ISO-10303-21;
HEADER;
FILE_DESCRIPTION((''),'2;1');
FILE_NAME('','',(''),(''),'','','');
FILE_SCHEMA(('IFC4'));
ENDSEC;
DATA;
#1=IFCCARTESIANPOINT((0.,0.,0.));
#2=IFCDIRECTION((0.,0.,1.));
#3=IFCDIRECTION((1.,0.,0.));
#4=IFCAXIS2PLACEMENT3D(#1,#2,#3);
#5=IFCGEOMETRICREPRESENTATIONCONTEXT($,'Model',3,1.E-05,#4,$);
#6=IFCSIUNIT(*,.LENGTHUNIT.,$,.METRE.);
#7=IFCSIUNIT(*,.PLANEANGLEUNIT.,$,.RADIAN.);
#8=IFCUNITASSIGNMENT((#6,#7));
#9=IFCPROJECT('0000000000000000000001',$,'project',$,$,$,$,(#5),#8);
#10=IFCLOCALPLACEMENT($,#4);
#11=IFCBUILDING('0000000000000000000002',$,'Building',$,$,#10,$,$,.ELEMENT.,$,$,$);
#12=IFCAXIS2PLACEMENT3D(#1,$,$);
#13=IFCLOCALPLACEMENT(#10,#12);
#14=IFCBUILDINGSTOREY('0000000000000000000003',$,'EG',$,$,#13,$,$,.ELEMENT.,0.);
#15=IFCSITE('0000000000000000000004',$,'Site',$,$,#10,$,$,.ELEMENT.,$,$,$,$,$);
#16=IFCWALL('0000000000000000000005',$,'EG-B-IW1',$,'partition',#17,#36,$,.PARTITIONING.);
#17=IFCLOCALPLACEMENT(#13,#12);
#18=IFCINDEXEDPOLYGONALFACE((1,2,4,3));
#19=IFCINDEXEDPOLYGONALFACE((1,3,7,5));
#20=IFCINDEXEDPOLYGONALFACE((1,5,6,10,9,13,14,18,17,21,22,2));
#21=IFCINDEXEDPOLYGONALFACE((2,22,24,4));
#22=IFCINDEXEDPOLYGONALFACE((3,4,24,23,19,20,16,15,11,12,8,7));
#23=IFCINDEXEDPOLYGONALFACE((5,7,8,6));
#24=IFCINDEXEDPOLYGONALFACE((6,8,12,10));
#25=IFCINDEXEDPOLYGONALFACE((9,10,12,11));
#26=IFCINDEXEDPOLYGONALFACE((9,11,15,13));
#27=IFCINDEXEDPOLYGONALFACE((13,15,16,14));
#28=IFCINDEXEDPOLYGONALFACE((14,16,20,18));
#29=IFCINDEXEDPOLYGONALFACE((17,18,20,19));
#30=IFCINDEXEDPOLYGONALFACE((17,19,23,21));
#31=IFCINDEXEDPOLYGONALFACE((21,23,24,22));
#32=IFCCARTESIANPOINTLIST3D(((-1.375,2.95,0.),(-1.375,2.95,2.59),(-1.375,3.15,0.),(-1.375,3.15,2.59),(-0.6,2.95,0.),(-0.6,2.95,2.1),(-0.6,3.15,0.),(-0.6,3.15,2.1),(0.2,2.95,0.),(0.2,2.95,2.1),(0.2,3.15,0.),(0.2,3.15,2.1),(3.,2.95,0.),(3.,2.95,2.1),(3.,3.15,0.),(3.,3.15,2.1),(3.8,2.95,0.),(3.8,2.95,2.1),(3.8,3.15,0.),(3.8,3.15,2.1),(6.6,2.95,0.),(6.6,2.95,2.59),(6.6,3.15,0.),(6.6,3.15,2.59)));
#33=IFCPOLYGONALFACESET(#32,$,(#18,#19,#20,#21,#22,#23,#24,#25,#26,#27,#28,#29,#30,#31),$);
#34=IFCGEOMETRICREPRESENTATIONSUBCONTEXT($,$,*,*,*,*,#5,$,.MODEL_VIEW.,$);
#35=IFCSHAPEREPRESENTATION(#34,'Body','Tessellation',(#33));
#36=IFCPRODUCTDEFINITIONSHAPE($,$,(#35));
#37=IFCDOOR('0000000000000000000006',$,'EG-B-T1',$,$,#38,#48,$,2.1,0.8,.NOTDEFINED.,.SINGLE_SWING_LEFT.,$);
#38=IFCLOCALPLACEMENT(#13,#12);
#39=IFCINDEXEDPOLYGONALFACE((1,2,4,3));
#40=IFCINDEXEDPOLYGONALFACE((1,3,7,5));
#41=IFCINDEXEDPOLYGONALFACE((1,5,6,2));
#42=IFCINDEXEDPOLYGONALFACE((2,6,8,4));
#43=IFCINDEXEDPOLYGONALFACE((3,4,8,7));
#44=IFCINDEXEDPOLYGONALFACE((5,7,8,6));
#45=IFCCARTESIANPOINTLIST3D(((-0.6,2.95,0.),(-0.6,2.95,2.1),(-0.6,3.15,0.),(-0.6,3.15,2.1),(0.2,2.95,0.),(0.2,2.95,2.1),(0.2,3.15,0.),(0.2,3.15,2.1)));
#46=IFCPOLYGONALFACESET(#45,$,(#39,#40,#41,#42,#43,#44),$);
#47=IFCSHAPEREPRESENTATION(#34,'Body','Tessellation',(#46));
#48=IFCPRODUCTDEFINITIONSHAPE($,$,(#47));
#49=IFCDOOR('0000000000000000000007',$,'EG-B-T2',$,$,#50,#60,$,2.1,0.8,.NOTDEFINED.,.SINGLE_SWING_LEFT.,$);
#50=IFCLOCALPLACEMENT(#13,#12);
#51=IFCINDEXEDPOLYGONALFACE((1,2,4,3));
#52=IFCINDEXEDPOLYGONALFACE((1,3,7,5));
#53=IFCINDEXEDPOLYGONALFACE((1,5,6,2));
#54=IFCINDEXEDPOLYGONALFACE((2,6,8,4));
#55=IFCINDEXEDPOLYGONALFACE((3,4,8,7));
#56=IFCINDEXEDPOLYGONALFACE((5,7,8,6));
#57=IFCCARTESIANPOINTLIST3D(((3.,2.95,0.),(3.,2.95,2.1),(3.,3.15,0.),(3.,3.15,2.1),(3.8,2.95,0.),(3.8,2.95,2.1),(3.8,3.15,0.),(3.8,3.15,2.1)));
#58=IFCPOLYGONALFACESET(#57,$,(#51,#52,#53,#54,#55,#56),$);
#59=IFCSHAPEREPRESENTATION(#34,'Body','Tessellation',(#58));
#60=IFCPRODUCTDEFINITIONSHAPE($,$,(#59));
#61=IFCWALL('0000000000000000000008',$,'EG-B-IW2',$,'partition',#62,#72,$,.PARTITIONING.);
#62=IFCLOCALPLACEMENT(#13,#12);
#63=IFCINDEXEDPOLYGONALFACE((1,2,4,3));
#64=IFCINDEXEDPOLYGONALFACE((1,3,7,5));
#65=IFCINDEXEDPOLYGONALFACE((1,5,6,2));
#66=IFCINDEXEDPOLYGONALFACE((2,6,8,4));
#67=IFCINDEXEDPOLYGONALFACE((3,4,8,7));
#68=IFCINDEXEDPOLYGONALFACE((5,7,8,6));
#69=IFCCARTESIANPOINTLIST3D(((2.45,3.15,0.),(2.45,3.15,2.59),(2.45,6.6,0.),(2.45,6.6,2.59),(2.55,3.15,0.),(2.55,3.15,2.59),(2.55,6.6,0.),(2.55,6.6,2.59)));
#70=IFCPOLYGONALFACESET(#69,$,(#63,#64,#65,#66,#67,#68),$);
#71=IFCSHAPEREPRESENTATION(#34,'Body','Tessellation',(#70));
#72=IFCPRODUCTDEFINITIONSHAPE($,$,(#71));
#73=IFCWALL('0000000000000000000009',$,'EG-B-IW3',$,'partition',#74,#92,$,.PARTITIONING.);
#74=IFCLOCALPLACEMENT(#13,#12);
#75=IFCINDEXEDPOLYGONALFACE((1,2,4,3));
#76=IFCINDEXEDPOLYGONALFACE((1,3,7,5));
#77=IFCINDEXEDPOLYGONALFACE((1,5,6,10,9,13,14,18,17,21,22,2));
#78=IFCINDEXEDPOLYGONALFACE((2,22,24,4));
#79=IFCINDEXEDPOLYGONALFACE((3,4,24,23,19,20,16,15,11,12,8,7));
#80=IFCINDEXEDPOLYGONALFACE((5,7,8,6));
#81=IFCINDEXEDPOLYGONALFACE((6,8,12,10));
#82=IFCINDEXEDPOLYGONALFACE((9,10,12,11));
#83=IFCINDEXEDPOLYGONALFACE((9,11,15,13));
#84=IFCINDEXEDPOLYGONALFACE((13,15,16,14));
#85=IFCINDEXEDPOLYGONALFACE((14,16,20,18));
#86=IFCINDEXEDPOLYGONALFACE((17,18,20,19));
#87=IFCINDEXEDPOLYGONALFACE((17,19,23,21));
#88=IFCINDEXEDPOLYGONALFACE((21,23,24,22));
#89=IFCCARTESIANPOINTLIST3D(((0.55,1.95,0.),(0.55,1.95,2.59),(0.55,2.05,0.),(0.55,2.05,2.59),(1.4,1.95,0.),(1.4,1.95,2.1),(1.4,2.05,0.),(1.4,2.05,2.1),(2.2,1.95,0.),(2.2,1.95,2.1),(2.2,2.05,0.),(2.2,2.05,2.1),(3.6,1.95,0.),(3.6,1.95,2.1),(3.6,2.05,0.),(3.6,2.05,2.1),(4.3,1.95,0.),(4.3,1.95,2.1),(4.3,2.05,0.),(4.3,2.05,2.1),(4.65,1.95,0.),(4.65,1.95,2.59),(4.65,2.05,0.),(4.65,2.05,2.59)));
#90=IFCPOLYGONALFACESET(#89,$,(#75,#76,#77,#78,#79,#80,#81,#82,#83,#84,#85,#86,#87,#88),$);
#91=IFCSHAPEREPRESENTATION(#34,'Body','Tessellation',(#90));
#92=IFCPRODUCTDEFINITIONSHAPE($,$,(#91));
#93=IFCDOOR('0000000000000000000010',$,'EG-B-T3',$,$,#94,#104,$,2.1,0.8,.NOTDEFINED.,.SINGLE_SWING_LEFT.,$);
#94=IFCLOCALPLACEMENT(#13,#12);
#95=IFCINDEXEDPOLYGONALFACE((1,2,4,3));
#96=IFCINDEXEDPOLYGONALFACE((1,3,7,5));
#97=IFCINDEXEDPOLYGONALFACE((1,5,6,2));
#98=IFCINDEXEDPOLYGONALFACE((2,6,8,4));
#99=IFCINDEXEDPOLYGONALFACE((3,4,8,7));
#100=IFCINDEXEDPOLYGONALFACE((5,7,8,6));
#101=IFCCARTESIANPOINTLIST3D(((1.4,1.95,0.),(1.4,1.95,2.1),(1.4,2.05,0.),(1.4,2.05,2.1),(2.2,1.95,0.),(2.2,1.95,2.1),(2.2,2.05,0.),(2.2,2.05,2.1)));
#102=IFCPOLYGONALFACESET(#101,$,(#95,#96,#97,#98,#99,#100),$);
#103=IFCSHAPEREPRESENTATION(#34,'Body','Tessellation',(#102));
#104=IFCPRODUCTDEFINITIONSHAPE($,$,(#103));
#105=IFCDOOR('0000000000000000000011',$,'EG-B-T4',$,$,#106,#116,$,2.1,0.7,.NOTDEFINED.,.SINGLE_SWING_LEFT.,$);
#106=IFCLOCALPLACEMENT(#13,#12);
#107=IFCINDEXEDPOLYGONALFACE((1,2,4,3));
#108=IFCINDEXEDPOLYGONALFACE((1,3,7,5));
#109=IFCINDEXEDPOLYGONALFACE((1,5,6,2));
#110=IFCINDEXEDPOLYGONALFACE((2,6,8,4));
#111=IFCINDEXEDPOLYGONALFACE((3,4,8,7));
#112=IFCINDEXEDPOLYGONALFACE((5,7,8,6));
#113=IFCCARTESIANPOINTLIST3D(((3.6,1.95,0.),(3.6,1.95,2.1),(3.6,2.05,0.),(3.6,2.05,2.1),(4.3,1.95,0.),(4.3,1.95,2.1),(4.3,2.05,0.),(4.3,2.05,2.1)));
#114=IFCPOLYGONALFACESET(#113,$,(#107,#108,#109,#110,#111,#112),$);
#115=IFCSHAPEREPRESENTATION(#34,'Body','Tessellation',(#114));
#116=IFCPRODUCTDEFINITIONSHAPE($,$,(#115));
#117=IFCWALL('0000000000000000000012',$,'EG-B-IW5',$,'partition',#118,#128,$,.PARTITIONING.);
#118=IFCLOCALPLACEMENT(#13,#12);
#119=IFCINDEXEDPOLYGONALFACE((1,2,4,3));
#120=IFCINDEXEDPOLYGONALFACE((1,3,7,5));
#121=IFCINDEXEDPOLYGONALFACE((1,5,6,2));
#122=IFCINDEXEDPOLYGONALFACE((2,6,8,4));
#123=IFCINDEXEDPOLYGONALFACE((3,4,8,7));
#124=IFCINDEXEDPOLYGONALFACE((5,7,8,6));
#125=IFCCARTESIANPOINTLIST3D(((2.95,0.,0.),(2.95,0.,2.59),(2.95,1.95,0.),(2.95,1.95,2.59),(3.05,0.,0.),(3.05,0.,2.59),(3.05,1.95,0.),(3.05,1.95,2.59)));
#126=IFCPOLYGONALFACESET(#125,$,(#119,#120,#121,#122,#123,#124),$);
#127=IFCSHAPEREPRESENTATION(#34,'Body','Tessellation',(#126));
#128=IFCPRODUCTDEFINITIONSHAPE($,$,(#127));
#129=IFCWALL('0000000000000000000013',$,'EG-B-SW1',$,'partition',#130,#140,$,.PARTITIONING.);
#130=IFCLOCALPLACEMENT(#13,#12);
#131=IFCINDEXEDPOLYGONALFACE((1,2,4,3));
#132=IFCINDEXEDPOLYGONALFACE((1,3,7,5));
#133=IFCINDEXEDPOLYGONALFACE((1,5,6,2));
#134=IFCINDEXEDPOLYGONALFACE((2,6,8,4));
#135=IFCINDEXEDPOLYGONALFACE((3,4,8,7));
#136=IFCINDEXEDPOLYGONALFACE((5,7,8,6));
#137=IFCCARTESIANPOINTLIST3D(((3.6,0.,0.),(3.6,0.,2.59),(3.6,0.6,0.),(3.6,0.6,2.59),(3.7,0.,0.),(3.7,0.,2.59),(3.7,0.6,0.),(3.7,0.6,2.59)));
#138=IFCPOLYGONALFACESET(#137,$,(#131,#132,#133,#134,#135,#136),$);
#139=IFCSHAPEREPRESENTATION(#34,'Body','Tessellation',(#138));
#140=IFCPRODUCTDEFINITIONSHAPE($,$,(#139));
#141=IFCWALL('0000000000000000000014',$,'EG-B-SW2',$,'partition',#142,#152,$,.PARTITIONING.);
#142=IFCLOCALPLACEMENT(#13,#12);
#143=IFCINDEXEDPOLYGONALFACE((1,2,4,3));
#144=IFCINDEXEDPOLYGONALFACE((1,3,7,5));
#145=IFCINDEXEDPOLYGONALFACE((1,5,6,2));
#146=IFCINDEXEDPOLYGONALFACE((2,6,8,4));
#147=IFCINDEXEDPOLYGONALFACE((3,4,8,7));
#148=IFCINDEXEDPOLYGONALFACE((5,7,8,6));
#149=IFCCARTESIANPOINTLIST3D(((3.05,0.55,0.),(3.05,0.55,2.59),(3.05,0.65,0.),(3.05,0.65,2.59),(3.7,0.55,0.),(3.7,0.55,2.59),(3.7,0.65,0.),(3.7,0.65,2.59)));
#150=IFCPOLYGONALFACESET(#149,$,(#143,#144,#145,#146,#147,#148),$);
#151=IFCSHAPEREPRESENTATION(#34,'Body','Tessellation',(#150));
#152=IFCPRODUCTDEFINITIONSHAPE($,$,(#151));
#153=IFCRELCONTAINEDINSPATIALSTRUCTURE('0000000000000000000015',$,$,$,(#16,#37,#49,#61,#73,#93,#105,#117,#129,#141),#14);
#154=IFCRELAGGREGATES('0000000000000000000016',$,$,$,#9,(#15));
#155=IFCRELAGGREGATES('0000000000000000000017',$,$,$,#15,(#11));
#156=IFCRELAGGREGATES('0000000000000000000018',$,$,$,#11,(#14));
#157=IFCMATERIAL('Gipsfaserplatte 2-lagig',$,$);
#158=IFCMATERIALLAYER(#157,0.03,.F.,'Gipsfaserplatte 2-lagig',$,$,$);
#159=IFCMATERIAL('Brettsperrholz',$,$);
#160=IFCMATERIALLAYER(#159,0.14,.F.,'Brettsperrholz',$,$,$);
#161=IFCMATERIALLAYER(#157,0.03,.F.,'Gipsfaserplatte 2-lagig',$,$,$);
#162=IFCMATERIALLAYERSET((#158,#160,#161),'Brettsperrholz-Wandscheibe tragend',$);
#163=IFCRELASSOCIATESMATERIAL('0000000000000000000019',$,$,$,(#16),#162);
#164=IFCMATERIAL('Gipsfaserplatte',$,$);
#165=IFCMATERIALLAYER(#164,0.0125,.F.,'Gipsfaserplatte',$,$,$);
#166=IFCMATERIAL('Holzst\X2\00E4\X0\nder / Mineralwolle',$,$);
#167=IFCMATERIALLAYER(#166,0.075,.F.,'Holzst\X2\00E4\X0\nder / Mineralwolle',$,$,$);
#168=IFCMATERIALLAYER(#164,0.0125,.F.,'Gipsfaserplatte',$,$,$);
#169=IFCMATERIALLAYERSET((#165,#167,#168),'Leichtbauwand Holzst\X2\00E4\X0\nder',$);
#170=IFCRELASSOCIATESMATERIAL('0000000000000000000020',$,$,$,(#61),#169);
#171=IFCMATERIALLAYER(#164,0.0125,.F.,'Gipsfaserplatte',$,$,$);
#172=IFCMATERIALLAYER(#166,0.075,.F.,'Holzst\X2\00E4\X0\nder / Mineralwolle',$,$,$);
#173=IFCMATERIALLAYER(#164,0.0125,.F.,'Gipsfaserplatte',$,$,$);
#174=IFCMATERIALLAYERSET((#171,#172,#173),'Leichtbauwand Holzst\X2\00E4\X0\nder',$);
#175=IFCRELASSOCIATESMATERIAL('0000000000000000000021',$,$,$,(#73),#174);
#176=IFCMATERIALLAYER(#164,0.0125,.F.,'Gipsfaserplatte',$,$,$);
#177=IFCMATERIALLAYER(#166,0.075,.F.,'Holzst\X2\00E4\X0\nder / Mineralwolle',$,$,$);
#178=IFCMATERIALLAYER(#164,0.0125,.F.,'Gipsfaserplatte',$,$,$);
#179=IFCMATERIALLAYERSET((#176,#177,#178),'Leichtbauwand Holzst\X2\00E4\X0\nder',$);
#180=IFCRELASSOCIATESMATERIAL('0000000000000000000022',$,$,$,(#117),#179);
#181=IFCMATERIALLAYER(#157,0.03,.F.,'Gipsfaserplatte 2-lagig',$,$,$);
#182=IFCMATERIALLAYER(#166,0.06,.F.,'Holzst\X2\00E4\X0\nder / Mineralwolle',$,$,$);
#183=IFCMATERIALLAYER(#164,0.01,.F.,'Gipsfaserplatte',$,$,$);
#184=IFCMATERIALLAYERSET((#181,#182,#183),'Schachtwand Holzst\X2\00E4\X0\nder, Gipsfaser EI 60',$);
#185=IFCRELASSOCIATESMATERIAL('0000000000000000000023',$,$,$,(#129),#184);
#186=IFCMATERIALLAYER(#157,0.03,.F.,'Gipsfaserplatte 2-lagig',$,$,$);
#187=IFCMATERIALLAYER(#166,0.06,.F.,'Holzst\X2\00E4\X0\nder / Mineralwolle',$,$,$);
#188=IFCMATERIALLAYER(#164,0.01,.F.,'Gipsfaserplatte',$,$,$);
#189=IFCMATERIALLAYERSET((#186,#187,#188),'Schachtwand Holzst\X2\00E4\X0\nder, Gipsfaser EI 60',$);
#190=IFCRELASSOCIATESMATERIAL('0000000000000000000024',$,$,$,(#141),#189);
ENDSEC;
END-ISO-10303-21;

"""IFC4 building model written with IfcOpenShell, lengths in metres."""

from ifc_helpers import new_model, si_unit, frame, frame_2d, origin, origin_with_axes, place, context, subcontext, project, spatial, rectangle, extrude, material, layer, layer_set, element, fill, save


model = new_model("IFC4")

# Units and contexts
model_context = context("Model", 3, precision=1e-05, world=origin_with_axes())
sub_context = subcontext(model_context, None, None, "MODEL_VIEW")
ifc_project = project(units=[si_unit("LENGTHUNIT", "METRE"), si_unit("PLANEANGLEUNIT", "RADIAN")], contexts=[model_context])

# Site, building, storey
placement = place(None, origin_with_axes())
site = spatial("IfcSite", under=ifc_project, at=placement, Name="Site", CompositionType="ELEMENT")
building = spatial("IfcBuilding", under=site, at=placement, Name="Building", CompositionType="ELEMENT")
storey_placement = place(placement, origin())
storey = spatial("IfcBuildingStorey", under=building, at=storey_placement, Name="EG", CompositionType="ELEMENT", Elevation=0.0)

# Shared definitions
ifc_material_1 = material(Name="Gipsfaserplatte")

# Wall, openings, doors
ifc_material_2 = material(Name="Gipsfaserplatte 2-lagig")
ifc_layer_1 = layer(ifc_material_2, 0.03, ventilated=False, Name="Gipsfaserplatte 2-lagig")
ifc_material_3 = material(Name="Brettsperrholz")
ifc_layer_2 = layer(ifc_material_3, 0.14, ventilated=False, Name="Brettsperrholz")
ifc_layer_3 = layer(ifc_material_2, 0.03, ventilated=False, Name="Gipsfaserplatte 2-lagig")
ifc_layer_set_1 = layer_set([ifc_layer_1, ifc_layer_2, ifc_layer_3], Name="Brettsperrholz-Wandscheibe tragend")
wall_1_placement = place(storey_placement, frame((-1.375, 3.05, 0.0), z_axis=(0.0, 0.0, 1.0), x_axis=(1.0, 0.0, 0.0)))
wall_1 = element("IfcWall", 1, at=wall_1_placement, inside=storey, material=ifc_layer_set_1, Name="EG-B-IW1", ObjectType="partition", PredefinedType="PARTITIONING", context=sub_context, shape_type="SweptSolid", body=[
    extrude(rectangle(XDim=7.975, YDim=0.2, at=frame_2d((3.9875, 0.0))), origin(), (0.0, 0.0, 1.0), 2.59),
])
opening_1_placement = place(wall_1_placement, frame((1.175, 0.15, 0.0), z_axis=(0.0, -1.0, 0.0), x_axis=(1.0, 0.0, 0.0)))
opening_1 = element("IfcOpeningElement", 2, at=opening_1_placement, cuts=wall_1, PredefinedType="OPENING", context=sub_context, shape_type="SweptSolid", body=[
    extrude(rectangle(XDim=0.8, YDim=2.1, at=frame_2d((0.0, 1.05))), origin(), (0.0, 0.0, 1.0), 0.3),
])
opening_2_placement = place(wall_1_placement, frame((4.775, 0.15, 0.0), z_axis=(0.0, -1.0, 0.0), x_axis=(1.0, 0.0, 0.0)))
opening_2 = element("IfcOpeningElement", 3, at=opening_2_placement, cuts=wall_1, PredefinedType="OPENING", context=sub_context, shape_type="SweptSolid", body=[
    extrude(rectangle(XDim=0.8, YDim=2.1, at=frame_2d((0.0, 1.05))), origin(), (0.0, 0.0, 1.0), 0.3),
])
door_1_placement = place(wall_1_placement, frame((1.175, 0.1, 0.0), z_axis=(0.0, -1.0, 0.0), x_axis=(1.0, 0.0, 0.0)))
door_1 = element("IfcDoor", 4, at=door_1_placement, inside=storey, Name="EG-B-T1", OperationType="SINGLE_SWING_LEFT", OverallHeight=2.1, OverallWidth=0.8, PredefinedType="NOTDEFINED", context=sub_context, shape_type="SweptSolid", body=[
    extrude(rectangle(XDim=0.8, YDim=2.1, at=frame_2d((0.0, 1.05))), origin(), (0.0, 0.0, 1.0), 0.2),
])
fill(opening_1, door_1)
door_2_placement = place(wall_1_placement, frame((4.775, 0.1, 0.0), z_axis=(0.0, -1.0, 0.0), x_axis=(1.0, 0.0, 0.0)))
door_2 = element("IfcDoor", 5, at=door_2_placement, inside=storey, Name="EG-B-T2", OperationType="SINGLE_SWING_LEFT", OverallHeight=2.1, OverallWidth=0.8, PredefinedType="NOTDEFINED", context=sub_context, shape_type="SweptSolid", body=[
    extrude(rectangle(XDim=0.8, YDim=2.1, at=frame_2d((0.0, 1.05))), origin(), (0.0, 0.0, 1.0), 0.2),
])
fill(opening_2, door_2)

# Wall
ifc_layer_4 = layer(ifc_material_1, 0.0125, ventilated=False, Name="Gipsfaserplatte")
ifc_material_4 = material(Name="Holzständer / Mineralwolle")
ifc_layer_5 = layer(ifc_material_4, 0.075, ventilated=False, Name="Holzständer / Mineralwolle")
ifc_layer_6 = layer(ifc_material_1, 0.0125, ventilated=False, Name="Gipsfaserplatte")
ifc_layer_set_2 = layer_set([ifc_layer_4, ifc_layer_5, ifc_layer_6], Name="Leichtbauwand Holzständer")
wall_2_placement = place(storey_placement, frame((2.5, 3.15, 0.0), z_axis=(0.0, 0.0, 1.0), x_axis=(0.0, 1.0, 0.0)))
element("IfcWall", 6, at=wall_2_placement, inside=storey, material=ifc_layer_set_2, Name="EG-B-IW2", ObjectType="partition", PredefinedType="PARTITIONING", context=sub_context, shape_type="SweptSolid", body=[
    extrude(rectangle(XDim=3.45, YDim=0.1, at=frame_2d((1.725, 0.0))), origin(), (0.0, 0.0, 1.0), 2.59),
])

# Wall, openings, doors
ifc_layer_7 = layer(ifc_material_1, 0.0125, ventilated=False, Name="Gipsfaserplatte")
ifc_layer_8 = layer(ifc_material_4, 0.075, ventilated=False, Name="Holzständer / Mineralwolle")
ifc_layer_9 = layer(ifc_material_1, 0.0125, ventilated=False, Name="Gipsfaserplatte")
ifc_layer_set_3 = layer_set([ifc_layer_7, ifc_layer_8, ifc_layer_9], Name="Leichtbauwand Holzständer")
wall_3_placement = place(storey_placement, frame((0.55, 2.0, 0.0), z_axis=(0.0, 0.0, 1.0), x_axis=(1.0, 0.0, 0.0)))
wall_3 = element("IfcWall", 7, at=wall_3_placement, inside=storey, material=ifc_layer_set_3, Name="EG-B-IW3", ObjectType="partition", PredefinedType="PARTITIONING", context=sub_context, shape_type="SweptSolid", body=[
    extrude(rectangle(XDim=4.1, YDim=0.1, at=frame_2d((2.05, 0.0))), origin(), (0.0, 0.0, 1.0), 2.59),
])
opening_3_placement = place(wall_3_placement, frame((1.25, 0.1, 0.0), z_axis=(0.0, -1.0, 0.0), x_axis=(1.0, 0.0, 0.0)))
opening_3 = element("IfcOpeningElement", 8, at=opening_3_placement, cuts=wall_3, PredefinedType="OPENING", context=sub_context, shape_type="SweptSolid", body=[
    extrude(rectangle(XDim=0.8, YDim=2.1, at=frame_2d((0.0, 1.05))), origin(), (0.0, 0.0, 1.0), 0.2),
])
opening_4_placement = place(wall_3_placement, frame((3.4, 0.1, 0.0), z_axis=(0.0, -1.0, 0.0), x_axis=(1.0, 0.0, 0.0)))
opening_4 = element("IfcOpeningElement", 9, at=opening_4_placement, cuts=wall_3, PredefinedType="OPENING", context=sub_context, shape_type="SweptSolid", body=[
    extrude(rectangle(XDim=0.7, YDim=2.1, at=frame_2d((0.0, 1.05))), origin(), (0.0, 0.0, 1.0), 0.2),
])
door_3_placement = place(wall_3_placement, frame((1.25, 0.05, 0.0), z_axis=(0.0, -1.0, 0.0), x_axis=(1.0, 0.0, 0.0)))
door_3 = element("IfcDoor", 10, at=door_3_placement, inside=storey, Name="EG-B-T3", OperationType="SINGLE_SWING_LEFT", OverallHeight=2.1, OverallWidth=0.8, PredefinedType="NOTDEFINED", context=sub_context, shape_type="SweptSolid", body=[
    extrude(rectangle(XDim=0.8, YDim=2.1, at=frame_2d((0.0, 1.05))), origin(), (0.0, 0.0, 1.0), 0.1),
])
fill(opening_3, door_3)
door_4_placement = place(wall_3_placement, frame((3.4, 0.05, 0.0), z_axis=(0.0, -1.0, 0.0), x_axis=(1.0, 0.0, 0.0)))
door_4 = element("IfcDoor", 11, at=door_4_placement, inside=storey, Name="EG-B-T4", OperationType="SINGLE_SWING_LEFT", OverallHeight=2.1, OverallWidth=0.7, PredefinedType="NOTDEFINED", context=sub_context, shape_type="SweptSolid", body=[
    extrude(rectangle(XDim=0.7, YDim=2.1, at=frame_2d((0.0, 1.05))), origin(), (0.0, 0.0, 1.0), 0.1),
])
fill(opening_4, door_4)

# Walls
ifc_layer_10 = layer(ifc_material_1, 0.0125, ventilated=False, Name="Gipsfaserplatte")
ifc_layer_11 = layer(ifc_material_4, 0.075, ventilated=False, Name="Holzständer / Mineralwolle")
ifc_layer_12 = layer(ifc_material_1, 0.0125, ventilated=False, Name="Gipsfaserplatte")
ifc_layer_set_4 = layer_set([ifc_layer_10, ifc_layer_11, ifc_layer_12], Name="Leichtbauwand Holzständer")
wall_4_placement = place(storey_placement, frame((3.0, 0.0, 0.0), z_axis=(0.0, 0.0, 1.0), x_axis=(0.0, 1.0, 0.0)))
element("IfcWall", 12, at=wall_4_placement, inside=storey, material=ifc_layer_set_4, Name="EG-B-IW5", ObjectType="partition", PredefinedType="PARTITIONING", context=sub_context, shape_type="SweptSolid", body=[
    extrude(rectangle(XDim=1.95, YDim=0.1, at=frame_2d((0.975, 0.0))), origin(), (0.0, 0.0, 1.0), 2.59),
])
ifc_layer_13 = layer(ifc_material_2, 0.03, ventilated=False, Name="Gipsfaserplatte 2-lagig")
ifc_layer_14 = layer(ifc_material_4, 0.06, ventilated=False, Name="Holzständer / Mineralwolle")
ifc_layer_15 = layer(ifc_material_1, 0.01, ventilated=False, Name="Gipsfaserplatte")
ifc_layer_set_5 = layer_set([ifc_layer_13, ifc_layer_14, ifc_layer_15], Name="Schachtwand Holzständer, Gipsfaser EI 60")
wall_5_placement = place(storey_placement, frame((3.65, 0.0, 0.0), z_axis=(0.0, 0.0, 1.0), x_axis=(0.0, 1.0, 0.0)))
element("IfcWall", 13, at=wall_5_placement, inside=storey, material=ifc_layer_set_5, Name="EG-B-SW1", ObjectType="partition", PredefinedType="PARTITIONING", context=sub_context, shape_type="SweptSolid", body=[
    extrude(rectangle(XDim=0.6, YDim=0.1, at=frame_2d((0.3, 0.0))), origin(), (0.0, 0.0, 1.0), 2.59),
])
ifc_layer_16 = layer(ifc_material_2, 0.03, ventilated=False, Name="Gipsfaserplatte 2-lagig")
ifc_layer_17 = layer(ifc_material_4, 0.06, ventilated=False, Name="Holzständer / Mineralwolle")
ifc_layer_18 = layer(ifc_material_1, 0.01, ventilated=False, Name="Gipsfaserplatte")
ifc_layer_set_6 = layer_set([ifc_layer_16, ifc_layer_17, ifc_layer_18], Name="Schachtwand Holzständer, Gipsfaser EI 60")
wall_6_placement = place(storey_placement, frame((3.05, 0.6, 0.0), z_axis=(0.0, 0.0, 1.0), x_axis=(1.0, 0.0, 0.0)))
element("IfcWall", 14, at=wall_6_placement, inside=storey, material=ifc_layer_set_6, Name="EG-B-SW2", ObjectType="partition", PredefinedType="PARTITIONING", context=sub_context, shape_type="SweptSolid", body=[
    extrude(rectangle(XDim=0.65, YDim=0.1, at=frame_2d((0.325, 0.0))), origin(), (0.0, 0.0, 1.0), 2.59),
])

save(model, "model.ifc")
